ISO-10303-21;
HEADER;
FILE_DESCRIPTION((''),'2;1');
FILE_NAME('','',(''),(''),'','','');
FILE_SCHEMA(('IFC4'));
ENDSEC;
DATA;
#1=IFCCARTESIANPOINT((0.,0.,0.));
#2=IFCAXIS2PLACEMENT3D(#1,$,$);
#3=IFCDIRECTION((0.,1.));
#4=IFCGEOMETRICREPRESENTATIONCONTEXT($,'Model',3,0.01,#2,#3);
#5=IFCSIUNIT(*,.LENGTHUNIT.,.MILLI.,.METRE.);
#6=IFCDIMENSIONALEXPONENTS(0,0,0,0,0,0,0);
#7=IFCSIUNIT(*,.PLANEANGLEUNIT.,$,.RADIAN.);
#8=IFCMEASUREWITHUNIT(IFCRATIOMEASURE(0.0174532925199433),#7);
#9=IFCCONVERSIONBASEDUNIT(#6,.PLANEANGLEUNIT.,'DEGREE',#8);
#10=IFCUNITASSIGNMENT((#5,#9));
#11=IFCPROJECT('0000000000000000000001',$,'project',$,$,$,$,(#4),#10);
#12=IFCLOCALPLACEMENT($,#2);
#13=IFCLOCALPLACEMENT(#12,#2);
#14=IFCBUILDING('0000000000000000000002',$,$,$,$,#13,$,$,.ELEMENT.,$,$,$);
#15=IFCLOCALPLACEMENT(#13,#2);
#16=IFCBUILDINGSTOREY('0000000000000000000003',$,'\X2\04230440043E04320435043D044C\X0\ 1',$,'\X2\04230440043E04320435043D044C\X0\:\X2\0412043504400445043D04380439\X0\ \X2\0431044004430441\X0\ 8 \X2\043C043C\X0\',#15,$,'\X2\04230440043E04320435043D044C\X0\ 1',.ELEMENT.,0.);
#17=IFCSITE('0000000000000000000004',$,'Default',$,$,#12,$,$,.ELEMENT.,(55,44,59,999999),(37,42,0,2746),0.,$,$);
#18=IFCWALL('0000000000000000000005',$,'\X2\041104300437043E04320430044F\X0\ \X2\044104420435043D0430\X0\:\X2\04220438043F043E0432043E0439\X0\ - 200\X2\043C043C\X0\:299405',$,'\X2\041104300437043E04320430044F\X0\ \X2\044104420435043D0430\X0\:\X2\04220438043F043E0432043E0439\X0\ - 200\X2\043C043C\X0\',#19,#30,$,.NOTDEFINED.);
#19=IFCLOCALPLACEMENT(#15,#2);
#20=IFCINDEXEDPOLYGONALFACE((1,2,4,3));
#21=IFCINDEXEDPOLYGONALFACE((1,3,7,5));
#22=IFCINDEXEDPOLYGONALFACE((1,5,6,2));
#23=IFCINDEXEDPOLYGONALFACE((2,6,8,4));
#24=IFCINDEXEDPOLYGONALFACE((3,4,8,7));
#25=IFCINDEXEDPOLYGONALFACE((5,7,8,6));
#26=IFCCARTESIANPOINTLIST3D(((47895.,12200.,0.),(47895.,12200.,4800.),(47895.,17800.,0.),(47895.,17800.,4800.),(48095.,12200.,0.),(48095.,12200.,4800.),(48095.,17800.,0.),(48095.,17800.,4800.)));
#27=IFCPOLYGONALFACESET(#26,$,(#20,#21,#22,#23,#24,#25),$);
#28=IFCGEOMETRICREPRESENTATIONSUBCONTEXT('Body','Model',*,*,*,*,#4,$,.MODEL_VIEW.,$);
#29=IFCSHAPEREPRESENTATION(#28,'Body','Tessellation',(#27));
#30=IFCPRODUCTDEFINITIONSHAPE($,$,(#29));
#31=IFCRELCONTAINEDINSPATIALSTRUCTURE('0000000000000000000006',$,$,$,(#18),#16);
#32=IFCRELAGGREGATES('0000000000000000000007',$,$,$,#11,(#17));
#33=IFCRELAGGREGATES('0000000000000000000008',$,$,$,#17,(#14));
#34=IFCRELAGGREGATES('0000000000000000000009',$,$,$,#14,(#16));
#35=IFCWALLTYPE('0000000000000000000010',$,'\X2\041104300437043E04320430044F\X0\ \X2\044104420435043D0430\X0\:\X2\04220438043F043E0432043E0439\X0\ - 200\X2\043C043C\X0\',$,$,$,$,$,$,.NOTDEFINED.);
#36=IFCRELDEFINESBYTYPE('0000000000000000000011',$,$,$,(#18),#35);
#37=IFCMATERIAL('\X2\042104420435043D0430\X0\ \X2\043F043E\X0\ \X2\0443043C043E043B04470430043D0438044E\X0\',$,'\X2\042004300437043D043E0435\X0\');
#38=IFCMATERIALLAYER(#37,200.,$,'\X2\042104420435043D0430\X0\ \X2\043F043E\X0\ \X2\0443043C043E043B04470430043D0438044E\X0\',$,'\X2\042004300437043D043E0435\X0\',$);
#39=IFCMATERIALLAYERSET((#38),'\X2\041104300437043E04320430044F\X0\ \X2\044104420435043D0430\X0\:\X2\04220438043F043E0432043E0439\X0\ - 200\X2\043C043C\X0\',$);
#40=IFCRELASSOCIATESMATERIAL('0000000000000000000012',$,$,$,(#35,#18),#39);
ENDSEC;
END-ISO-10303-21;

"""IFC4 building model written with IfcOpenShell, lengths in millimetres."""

from ifc_helpers import new_model, entity, si_unit, converted_unit, direction, frame, frame_2d, origin, place, context, subcontext, project, spatial, rectangle, extrude, material, layer, layer_set, layer_usage, type_object, element, save


model = new_model("IFC4")

# Units and contexts
model_context = context("Model", 3, precision=0.01, world=origin(), true_north=direction((0.0, 1.0)))
body_context = subcontext(model_context, "Body", "Model", "MODEL_VIEW")
ifc_project = project(units=[si_unit("LENGTHUNIT", "METRE", prefix="MILLI"), converted_unit("PLANEANGLEUNIT", "DEGREE", entity("IfcRatioMeasure", 0.0174532925199433), si_unit("PLANEANGLEUNIT", "RADIAN"), dimensions=[0, 0, 0, 0, 0, 0, 0])], contexts=[model_context])

# Site, building, storey
site_placement = place(None, origin())
site = spatial("IfcSite", under=ifc_project, at=site_placement, Name="Default", CompositionType="ELEMENT", RefLatitude=(55, 44, 59, 999999), RefLongitude=(37, 42, 0, 2746), RefElevation=0.0)
building_placement = place(site_placement, origin())
building = spatial("IfcBuilding", under=site, at=building_placement, CompositionType="ELEMENT")
storey_placement = place(building_placement, origin())
storey = spatial("IfcBuildingStorey", under=building, at=storey_placement, Name="Уровень 1", ObjectType="Уровень:Верхний брус 8 мм", LongName="Уровень 1", CompositionType="ELEMENT", Elevation=0.0)

# Shared definitions
ifc_material_1 = material(Name="Стена по умолчанию", Category="Разное")
ifc_layer = layer(ifc_material_1, 200.0, Name="Стена по умолчанию", Category="Разное")
ifc_layer_set = layer_set([ifc_layer], Name="Базовая стена:Типовой - 200мм")
wall_type = type_object("IfcWallType", Name="Базовая стена:Типовой - 200мм", PredefinedType="NOTDEFINED", material=ifc_layer_set)

# Wall
ifc_layer_usage_1 = layer_usage(ifc_layer_set, "AXIS2", "NEGATIVE", 100.0)
wall_1_placement = place(storey_placement, frame((47995.0, 12200.0, 0.0), z_axis=(0.0, 0.0, 1.0), x_axis=(0.0, 1.0, 0.0)))
element("IfcWall", 1, at=wall_1_placement, inside=storey, type_object=wall_type, material=ifc_layer_usage_1, Name="Базовая стена:Типовой - 200мм:299405", ObjectType="Базовая стена:Типовой - 200мм", PredefinedType="NOTDEFINED", context=body_context, shape_type="SweptSolid", body=[
    extrude(rectangle(XDim=5600.0, YDim=200.0, at=frame_2d((2800.0, 0.0), x_axis=(-1.0, 0.0))), origin(), (0.0, 0.0, 1.0), 4800.0),
])

save(model, "model.ifc")
